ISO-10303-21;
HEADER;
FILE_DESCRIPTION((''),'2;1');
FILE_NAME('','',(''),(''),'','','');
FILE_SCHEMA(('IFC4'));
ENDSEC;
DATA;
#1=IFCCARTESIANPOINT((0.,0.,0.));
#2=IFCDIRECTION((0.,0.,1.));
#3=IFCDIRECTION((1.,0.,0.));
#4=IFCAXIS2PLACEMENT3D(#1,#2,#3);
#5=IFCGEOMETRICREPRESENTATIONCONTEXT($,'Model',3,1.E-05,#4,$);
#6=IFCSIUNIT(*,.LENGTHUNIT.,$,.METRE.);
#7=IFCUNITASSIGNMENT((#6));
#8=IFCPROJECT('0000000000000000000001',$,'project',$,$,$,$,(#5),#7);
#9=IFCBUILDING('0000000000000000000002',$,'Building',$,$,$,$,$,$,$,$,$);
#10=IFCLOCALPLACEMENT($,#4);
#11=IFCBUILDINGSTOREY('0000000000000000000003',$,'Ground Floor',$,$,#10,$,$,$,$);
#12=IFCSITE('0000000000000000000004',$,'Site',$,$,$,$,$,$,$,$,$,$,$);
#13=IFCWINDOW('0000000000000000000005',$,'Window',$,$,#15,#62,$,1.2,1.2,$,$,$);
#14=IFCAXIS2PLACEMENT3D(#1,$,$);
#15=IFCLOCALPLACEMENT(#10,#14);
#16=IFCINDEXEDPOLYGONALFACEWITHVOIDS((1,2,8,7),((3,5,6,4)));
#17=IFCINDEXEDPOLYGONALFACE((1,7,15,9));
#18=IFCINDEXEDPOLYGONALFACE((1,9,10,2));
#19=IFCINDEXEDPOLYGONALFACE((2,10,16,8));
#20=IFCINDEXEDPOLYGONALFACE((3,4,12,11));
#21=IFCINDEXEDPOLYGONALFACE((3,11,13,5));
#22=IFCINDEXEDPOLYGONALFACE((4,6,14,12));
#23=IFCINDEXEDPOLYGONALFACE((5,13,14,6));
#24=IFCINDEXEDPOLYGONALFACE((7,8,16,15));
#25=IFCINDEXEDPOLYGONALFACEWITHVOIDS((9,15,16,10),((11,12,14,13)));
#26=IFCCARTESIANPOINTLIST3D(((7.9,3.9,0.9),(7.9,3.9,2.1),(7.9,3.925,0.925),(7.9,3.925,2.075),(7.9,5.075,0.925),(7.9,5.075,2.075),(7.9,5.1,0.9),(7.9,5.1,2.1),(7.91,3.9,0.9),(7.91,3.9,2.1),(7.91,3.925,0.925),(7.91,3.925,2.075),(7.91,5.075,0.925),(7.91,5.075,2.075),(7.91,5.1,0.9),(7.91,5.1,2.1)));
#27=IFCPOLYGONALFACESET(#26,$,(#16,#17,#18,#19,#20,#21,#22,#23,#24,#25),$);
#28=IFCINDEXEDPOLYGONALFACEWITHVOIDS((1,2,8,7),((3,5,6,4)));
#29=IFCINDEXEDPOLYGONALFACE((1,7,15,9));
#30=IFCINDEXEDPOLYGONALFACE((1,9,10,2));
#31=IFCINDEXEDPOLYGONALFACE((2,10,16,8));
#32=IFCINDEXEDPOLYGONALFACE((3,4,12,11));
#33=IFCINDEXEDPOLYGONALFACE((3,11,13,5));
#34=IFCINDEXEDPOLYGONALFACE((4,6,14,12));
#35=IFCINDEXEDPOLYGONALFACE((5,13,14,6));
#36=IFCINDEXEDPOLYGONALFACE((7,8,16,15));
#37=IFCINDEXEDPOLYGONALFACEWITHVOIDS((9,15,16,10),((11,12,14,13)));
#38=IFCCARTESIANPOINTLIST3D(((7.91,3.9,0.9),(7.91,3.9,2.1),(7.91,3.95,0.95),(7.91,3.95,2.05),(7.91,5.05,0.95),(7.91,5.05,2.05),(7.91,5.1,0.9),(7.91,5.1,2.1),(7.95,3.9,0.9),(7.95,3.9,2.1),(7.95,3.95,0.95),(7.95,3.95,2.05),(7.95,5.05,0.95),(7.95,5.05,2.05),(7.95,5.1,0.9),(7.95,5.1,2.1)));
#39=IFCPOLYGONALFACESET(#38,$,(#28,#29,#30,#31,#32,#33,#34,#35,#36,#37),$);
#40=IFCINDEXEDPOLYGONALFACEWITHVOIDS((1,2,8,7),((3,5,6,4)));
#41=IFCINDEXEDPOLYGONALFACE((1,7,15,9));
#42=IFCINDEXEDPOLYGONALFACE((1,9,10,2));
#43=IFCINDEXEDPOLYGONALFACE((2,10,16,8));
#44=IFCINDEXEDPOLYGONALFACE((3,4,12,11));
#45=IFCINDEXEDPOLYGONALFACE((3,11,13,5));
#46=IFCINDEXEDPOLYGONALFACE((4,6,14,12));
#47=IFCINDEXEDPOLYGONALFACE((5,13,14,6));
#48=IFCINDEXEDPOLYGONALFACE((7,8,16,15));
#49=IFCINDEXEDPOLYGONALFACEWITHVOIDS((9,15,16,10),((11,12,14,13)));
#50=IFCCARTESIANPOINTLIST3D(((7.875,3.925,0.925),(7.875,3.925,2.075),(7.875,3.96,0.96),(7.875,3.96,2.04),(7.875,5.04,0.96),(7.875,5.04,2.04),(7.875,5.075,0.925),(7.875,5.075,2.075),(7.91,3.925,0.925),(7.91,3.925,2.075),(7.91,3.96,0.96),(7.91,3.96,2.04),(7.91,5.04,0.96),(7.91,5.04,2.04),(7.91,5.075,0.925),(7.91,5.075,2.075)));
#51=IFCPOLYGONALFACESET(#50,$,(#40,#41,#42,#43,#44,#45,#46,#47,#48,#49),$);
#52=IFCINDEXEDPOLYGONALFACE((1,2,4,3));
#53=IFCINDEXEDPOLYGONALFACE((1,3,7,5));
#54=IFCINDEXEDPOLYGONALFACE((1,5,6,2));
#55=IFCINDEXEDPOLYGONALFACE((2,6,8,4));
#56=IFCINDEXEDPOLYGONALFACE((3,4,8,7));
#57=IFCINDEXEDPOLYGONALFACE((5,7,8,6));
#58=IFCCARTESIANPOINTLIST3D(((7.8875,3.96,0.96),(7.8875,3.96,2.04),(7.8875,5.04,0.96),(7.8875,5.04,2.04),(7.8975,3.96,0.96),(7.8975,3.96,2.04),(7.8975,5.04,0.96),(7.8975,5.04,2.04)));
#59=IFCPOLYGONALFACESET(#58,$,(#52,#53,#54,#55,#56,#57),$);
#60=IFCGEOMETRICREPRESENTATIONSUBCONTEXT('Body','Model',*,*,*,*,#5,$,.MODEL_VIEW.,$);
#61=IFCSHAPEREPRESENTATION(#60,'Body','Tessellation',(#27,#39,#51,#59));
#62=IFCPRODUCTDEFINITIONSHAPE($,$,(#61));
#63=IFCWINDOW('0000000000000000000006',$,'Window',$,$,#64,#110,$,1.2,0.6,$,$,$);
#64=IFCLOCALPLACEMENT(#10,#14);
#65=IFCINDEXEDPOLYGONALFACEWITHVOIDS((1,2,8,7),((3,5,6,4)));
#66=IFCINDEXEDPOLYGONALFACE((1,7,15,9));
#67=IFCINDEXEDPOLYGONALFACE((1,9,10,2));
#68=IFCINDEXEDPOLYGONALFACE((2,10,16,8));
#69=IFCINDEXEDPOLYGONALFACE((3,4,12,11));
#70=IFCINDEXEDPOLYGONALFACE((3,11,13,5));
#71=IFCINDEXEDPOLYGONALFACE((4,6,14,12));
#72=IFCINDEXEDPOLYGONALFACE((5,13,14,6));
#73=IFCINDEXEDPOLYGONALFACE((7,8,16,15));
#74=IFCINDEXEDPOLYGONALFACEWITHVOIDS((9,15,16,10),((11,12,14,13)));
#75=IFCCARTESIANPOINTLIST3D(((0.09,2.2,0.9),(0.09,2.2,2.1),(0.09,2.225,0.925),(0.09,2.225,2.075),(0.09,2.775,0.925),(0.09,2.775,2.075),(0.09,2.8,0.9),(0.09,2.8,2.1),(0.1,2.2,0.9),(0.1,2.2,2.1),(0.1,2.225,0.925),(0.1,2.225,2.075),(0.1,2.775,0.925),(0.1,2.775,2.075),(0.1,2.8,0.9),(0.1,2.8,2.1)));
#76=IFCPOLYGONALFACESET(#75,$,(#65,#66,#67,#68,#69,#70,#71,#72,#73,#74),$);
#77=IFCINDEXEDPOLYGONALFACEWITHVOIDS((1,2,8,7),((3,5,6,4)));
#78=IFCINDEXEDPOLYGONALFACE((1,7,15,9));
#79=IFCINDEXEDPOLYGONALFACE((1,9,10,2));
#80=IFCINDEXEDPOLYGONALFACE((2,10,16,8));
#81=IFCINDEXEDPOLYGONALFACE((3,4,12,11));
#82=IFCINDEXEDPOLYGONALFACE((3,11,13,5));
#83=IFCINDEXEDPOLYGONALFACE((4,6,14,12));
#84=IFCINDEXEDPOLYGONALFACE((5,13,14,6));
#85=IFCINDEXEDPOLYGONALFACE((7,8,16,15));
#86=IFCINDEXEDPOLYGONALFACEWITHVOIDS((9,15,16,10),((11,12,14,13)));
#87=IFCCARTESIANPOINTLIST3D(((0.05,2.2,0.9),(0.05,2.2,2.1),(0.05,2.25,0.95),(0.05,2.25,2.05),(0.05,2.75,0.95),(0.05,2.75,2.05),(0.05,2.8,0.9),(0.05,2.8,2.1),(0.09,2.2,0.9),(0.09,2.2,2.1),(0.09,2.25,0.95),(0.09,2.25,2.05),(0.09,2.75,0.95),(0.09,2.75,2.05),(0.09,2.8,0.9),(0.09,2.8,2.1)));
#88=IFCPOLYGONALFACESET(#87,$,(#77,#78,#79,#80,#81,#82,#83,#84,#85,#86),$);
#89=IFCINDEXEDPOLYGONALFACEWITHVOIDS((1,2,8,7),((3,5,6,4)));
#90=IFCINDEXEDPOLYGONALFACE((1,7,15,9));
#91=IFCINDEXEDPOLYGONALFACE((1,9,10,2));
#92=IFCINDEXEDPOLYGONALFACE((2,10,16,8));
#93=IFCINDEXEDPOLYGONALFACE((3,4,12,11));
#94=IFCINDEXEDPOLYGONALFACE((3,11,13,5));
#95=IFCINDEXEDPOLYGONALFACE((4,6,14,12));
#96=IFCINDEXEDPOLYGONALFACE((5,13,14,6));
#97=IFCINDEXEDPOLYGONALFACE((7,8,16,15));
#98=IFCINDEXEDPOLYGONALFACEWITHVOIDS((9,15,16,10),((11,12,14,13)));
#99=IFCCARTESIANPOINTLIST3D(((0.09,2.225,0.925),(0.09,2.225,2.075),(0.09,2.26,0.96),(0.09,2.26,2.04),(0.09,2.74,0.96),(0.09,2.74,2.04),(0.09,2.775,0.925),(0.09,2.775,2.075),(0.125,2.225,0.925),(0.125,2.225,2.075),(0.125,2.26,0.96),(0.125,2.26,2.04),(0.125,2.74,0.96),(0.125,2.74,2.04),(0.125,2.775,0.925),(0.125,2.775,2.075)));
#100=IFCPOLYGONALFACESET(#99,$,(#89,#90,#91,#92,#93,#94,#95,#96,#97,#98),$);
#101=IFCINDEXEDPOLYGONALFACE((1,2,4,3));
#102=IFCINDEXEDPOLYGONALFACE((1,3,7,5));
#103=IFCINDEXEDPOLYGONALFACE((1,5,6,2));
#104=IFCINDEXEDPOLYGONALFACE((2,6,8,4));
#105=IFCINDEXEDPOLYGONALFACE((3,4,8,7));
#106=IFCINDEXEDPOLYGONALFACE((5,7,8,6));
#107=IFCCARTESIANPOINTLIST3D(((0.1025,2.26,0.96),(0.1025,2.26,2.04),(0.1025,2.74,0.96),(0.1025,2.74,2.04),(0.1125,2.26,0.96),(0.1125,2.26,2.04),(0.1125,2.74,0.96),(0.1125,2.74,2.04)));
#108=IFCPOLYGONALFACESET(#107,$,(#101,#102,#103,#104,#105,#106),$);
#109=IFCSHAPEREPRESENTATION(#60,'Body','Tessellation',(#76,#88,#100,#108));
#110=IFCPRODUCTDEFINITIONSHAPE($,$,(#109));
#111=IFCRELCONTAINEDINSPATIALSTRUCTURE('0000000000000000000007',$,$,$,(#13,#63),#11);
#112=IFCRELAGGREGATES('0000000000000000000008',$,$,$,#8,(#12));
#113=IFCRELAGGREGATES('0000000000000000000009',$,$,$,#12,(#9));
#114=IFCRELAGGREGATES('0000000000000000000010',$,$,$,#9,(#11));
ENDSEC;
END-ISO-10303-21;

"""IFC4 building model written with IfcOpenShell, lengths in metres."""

from ifc_helpers import new_model, si_unit, frame, origin_with_axes, place, context, subcontext, project, spatial, line, indexed_curve, outline, extrude, element, save


model = new_model("IFC4")

# Units and contexts
model_context = context("Model", 3, precision=1e-05, world=origin_with_axes())
body_context = subcontext(model_context, "Body", "Model", "MODEL_VIEW")
ifc_project = project(units=[si_unit("LENGTHUNIT", "METRE")], contexts=[model_context])

# Site, building, storey
site = spatial("IfcSite", under=ifc_project, Name="Site")
building = spatial("IfcBuilding", under=site, Name="Building")
storey_placement = place(None, origin_with_axes())
storey = spatial("IfcBuildingStorey", under=building, at=storey_placement, Name="Ground Floor")

# Windows
window_1_placement = place(storey_placement, frame((8.0, 3.9, 0.9), z_axis=(0.0, 0.0, 1.0), x_axis=(0.0, 1.0, 0.0)))
element("IfcWindow", 1, at=window_1_placement, inside=storey, Name="Window", OverallHeight=1.2, OverallWidth=1.2, context=body_context, shape_type="SweptSolid", body=[
    extrude(outline(indexed_curve([(0.0, 0.0), (1.2, 0.0), (1.2, 1.2), (0.0, 1.2)], segments=[line(1, 2, 3, 4, 1)]), holes=[indexed_curve([(0.025, 0.025), (1.175, 0.025), (1.175, 1.175), (0.025, 1.175)], segments=[line(1, 2, 3, 4, 1)])]), frame((0.0, 0.09, 0.0), z_axis=(0.0, -1.0, 0.0), x_axis=(1.0, 0.0, 0.0)), (0.0, 0.0, -1.0), 0.01),
    extrude(outline(indexed_curve([(0.0, 0.0), (1.2, 0.0), (1.2, 1.2), (0.0, 1.2)], segments=[line(1, 2, 3, 4, 1)]), holes=[indexed_curve([(0.05, 0.05), (1.15, 0.05), (1.15, 1.15), (0.05, 1.15)], segments=[line(1, 2, 3, 4, 1)])]), frame((0.0, 0.05, 0.0), z_axis=(0.0, -1.0, 0.0), x_axis=(1.0, 0.0, 0.0)), (0.0, 0.0, -1.0), 0.04),
    extrude(outline(indexed_curve([(0.0, 0.0), (1.15, 0.0), (1.15, 1.15), (0.0, 1.15)], segments=[line(1, 2, 3, 4, 1)]), holes=[indexed_curve([(0.035, 0.035), (1.115, 0.035), (1.115, 1.115), (0.035, 1.115)], segments=[line(1, 2, 3, 4, 1)])]), frame((0.025, 0.09, 0.025), z_axis=(0.0, -1.0, 0.0), x_axis=(1.0, 0.0, 0.0)), (0.0, 0.0, -1.0), 0.035),
    extrude(outline(indexed_curve([(0.035, 0.035), (1.115, 0.035), (1.115, 1.115), (0.035, 1.115)], segments=[line(1, 2, 3, 4, 1)])), frame((0.025, 0.1025, 0.025), z_axis=(0.0, -1.0, 0.0), x_axis=(1.0, 0.0, 0.0)), (0.0, 0.0, -1.0), 0.01),
])
window_2_placement = place(storey_placement, frame((0.0, 2.8, 0.9), z_axis=(0.0, 0.0, 1.0), x_axis=(0.0, -1.0, 0.0)))
element("IfcWindow", 2, at=window_2_placement, inside=storey, Name="Window", OverallHeight=1.2, OverallWidth=0.6, context=body_context, shape_type="SweptSolid", body=[
    extrude(outline(indexed_curve([(0.0, 0.0), (0.6, 0.0), (0.6, 1.2), (0.0, 1.2)], segments=[line(1, 2, 3, 4, 1)]), holes=[indexed_curve([(0.025, 0.025), (0.575, 0.025), (0.575, 1.175), (0.025, 1.175)], segments=[line(1, 2, 3, 4, 1)])]), frame((0.0, 0.09, 0.0), z_axis=(0.0, -1.0, 0.0), x_axis=(1.0, 0.0, 0.0)), (0.0, 0.0, -1.0), 0.01),
    extrude(outline(indexed_curve([(0.0, 0.0), (0.6, 0.0), (0.6, 1.2), (0.0, 1.2)], segments=[line(1, 2, 3, 4, 1)]), holes=[indexed_curve([(0.05, 0.05), (0.55, 0.05), (0.55, 1.15), (0.05, 1.15)], segments=[line(1, 2, 3, 4, 1)])]), frame((0.0, 0.05, 0.0), z_axis=(0.0, -1.0, 0.0), x_axis=(1.0, 0.0, 0.0)), (0.0, 0.0, -1.0), 0.04),
    extrude(outline(indexed_curve([(0.0, 0.0), (0.55, 0.0), (0.55, 1.15), (0.0, 1.15)], segments=[line(1, 2, 3, 4, 1)]), holes=[indexed_curve([(0.035, 0.035), (0.515, 0.035), (0.515, 1.115), (0.035, 1.115)], segments=[line(1, 2, 3, 4, 1)])]), frame((0.025, 0.09, 0.025), z_axis=(0.0, -1.0, 0.0), x_axis=(1.0, 0.0, 0.0)), (0.0, 0.0, -1.0), 0.035),
    extrude(outline(indexed_curve([(0.035, 0.035), (0.515, 0.035), (0.515, 1.115), (0.035, 1.115)], segments=[line(1, 2, 3, 4, 1)])), frame((0.025, 0.1025, 0.025), z_axis=(0.0, -1.0, 0.0), x_axis=(1.0, 0.0, 0.0)), (0.0, 0.0, -1.0), 0.01),
])

save(model, "model.ifc")
